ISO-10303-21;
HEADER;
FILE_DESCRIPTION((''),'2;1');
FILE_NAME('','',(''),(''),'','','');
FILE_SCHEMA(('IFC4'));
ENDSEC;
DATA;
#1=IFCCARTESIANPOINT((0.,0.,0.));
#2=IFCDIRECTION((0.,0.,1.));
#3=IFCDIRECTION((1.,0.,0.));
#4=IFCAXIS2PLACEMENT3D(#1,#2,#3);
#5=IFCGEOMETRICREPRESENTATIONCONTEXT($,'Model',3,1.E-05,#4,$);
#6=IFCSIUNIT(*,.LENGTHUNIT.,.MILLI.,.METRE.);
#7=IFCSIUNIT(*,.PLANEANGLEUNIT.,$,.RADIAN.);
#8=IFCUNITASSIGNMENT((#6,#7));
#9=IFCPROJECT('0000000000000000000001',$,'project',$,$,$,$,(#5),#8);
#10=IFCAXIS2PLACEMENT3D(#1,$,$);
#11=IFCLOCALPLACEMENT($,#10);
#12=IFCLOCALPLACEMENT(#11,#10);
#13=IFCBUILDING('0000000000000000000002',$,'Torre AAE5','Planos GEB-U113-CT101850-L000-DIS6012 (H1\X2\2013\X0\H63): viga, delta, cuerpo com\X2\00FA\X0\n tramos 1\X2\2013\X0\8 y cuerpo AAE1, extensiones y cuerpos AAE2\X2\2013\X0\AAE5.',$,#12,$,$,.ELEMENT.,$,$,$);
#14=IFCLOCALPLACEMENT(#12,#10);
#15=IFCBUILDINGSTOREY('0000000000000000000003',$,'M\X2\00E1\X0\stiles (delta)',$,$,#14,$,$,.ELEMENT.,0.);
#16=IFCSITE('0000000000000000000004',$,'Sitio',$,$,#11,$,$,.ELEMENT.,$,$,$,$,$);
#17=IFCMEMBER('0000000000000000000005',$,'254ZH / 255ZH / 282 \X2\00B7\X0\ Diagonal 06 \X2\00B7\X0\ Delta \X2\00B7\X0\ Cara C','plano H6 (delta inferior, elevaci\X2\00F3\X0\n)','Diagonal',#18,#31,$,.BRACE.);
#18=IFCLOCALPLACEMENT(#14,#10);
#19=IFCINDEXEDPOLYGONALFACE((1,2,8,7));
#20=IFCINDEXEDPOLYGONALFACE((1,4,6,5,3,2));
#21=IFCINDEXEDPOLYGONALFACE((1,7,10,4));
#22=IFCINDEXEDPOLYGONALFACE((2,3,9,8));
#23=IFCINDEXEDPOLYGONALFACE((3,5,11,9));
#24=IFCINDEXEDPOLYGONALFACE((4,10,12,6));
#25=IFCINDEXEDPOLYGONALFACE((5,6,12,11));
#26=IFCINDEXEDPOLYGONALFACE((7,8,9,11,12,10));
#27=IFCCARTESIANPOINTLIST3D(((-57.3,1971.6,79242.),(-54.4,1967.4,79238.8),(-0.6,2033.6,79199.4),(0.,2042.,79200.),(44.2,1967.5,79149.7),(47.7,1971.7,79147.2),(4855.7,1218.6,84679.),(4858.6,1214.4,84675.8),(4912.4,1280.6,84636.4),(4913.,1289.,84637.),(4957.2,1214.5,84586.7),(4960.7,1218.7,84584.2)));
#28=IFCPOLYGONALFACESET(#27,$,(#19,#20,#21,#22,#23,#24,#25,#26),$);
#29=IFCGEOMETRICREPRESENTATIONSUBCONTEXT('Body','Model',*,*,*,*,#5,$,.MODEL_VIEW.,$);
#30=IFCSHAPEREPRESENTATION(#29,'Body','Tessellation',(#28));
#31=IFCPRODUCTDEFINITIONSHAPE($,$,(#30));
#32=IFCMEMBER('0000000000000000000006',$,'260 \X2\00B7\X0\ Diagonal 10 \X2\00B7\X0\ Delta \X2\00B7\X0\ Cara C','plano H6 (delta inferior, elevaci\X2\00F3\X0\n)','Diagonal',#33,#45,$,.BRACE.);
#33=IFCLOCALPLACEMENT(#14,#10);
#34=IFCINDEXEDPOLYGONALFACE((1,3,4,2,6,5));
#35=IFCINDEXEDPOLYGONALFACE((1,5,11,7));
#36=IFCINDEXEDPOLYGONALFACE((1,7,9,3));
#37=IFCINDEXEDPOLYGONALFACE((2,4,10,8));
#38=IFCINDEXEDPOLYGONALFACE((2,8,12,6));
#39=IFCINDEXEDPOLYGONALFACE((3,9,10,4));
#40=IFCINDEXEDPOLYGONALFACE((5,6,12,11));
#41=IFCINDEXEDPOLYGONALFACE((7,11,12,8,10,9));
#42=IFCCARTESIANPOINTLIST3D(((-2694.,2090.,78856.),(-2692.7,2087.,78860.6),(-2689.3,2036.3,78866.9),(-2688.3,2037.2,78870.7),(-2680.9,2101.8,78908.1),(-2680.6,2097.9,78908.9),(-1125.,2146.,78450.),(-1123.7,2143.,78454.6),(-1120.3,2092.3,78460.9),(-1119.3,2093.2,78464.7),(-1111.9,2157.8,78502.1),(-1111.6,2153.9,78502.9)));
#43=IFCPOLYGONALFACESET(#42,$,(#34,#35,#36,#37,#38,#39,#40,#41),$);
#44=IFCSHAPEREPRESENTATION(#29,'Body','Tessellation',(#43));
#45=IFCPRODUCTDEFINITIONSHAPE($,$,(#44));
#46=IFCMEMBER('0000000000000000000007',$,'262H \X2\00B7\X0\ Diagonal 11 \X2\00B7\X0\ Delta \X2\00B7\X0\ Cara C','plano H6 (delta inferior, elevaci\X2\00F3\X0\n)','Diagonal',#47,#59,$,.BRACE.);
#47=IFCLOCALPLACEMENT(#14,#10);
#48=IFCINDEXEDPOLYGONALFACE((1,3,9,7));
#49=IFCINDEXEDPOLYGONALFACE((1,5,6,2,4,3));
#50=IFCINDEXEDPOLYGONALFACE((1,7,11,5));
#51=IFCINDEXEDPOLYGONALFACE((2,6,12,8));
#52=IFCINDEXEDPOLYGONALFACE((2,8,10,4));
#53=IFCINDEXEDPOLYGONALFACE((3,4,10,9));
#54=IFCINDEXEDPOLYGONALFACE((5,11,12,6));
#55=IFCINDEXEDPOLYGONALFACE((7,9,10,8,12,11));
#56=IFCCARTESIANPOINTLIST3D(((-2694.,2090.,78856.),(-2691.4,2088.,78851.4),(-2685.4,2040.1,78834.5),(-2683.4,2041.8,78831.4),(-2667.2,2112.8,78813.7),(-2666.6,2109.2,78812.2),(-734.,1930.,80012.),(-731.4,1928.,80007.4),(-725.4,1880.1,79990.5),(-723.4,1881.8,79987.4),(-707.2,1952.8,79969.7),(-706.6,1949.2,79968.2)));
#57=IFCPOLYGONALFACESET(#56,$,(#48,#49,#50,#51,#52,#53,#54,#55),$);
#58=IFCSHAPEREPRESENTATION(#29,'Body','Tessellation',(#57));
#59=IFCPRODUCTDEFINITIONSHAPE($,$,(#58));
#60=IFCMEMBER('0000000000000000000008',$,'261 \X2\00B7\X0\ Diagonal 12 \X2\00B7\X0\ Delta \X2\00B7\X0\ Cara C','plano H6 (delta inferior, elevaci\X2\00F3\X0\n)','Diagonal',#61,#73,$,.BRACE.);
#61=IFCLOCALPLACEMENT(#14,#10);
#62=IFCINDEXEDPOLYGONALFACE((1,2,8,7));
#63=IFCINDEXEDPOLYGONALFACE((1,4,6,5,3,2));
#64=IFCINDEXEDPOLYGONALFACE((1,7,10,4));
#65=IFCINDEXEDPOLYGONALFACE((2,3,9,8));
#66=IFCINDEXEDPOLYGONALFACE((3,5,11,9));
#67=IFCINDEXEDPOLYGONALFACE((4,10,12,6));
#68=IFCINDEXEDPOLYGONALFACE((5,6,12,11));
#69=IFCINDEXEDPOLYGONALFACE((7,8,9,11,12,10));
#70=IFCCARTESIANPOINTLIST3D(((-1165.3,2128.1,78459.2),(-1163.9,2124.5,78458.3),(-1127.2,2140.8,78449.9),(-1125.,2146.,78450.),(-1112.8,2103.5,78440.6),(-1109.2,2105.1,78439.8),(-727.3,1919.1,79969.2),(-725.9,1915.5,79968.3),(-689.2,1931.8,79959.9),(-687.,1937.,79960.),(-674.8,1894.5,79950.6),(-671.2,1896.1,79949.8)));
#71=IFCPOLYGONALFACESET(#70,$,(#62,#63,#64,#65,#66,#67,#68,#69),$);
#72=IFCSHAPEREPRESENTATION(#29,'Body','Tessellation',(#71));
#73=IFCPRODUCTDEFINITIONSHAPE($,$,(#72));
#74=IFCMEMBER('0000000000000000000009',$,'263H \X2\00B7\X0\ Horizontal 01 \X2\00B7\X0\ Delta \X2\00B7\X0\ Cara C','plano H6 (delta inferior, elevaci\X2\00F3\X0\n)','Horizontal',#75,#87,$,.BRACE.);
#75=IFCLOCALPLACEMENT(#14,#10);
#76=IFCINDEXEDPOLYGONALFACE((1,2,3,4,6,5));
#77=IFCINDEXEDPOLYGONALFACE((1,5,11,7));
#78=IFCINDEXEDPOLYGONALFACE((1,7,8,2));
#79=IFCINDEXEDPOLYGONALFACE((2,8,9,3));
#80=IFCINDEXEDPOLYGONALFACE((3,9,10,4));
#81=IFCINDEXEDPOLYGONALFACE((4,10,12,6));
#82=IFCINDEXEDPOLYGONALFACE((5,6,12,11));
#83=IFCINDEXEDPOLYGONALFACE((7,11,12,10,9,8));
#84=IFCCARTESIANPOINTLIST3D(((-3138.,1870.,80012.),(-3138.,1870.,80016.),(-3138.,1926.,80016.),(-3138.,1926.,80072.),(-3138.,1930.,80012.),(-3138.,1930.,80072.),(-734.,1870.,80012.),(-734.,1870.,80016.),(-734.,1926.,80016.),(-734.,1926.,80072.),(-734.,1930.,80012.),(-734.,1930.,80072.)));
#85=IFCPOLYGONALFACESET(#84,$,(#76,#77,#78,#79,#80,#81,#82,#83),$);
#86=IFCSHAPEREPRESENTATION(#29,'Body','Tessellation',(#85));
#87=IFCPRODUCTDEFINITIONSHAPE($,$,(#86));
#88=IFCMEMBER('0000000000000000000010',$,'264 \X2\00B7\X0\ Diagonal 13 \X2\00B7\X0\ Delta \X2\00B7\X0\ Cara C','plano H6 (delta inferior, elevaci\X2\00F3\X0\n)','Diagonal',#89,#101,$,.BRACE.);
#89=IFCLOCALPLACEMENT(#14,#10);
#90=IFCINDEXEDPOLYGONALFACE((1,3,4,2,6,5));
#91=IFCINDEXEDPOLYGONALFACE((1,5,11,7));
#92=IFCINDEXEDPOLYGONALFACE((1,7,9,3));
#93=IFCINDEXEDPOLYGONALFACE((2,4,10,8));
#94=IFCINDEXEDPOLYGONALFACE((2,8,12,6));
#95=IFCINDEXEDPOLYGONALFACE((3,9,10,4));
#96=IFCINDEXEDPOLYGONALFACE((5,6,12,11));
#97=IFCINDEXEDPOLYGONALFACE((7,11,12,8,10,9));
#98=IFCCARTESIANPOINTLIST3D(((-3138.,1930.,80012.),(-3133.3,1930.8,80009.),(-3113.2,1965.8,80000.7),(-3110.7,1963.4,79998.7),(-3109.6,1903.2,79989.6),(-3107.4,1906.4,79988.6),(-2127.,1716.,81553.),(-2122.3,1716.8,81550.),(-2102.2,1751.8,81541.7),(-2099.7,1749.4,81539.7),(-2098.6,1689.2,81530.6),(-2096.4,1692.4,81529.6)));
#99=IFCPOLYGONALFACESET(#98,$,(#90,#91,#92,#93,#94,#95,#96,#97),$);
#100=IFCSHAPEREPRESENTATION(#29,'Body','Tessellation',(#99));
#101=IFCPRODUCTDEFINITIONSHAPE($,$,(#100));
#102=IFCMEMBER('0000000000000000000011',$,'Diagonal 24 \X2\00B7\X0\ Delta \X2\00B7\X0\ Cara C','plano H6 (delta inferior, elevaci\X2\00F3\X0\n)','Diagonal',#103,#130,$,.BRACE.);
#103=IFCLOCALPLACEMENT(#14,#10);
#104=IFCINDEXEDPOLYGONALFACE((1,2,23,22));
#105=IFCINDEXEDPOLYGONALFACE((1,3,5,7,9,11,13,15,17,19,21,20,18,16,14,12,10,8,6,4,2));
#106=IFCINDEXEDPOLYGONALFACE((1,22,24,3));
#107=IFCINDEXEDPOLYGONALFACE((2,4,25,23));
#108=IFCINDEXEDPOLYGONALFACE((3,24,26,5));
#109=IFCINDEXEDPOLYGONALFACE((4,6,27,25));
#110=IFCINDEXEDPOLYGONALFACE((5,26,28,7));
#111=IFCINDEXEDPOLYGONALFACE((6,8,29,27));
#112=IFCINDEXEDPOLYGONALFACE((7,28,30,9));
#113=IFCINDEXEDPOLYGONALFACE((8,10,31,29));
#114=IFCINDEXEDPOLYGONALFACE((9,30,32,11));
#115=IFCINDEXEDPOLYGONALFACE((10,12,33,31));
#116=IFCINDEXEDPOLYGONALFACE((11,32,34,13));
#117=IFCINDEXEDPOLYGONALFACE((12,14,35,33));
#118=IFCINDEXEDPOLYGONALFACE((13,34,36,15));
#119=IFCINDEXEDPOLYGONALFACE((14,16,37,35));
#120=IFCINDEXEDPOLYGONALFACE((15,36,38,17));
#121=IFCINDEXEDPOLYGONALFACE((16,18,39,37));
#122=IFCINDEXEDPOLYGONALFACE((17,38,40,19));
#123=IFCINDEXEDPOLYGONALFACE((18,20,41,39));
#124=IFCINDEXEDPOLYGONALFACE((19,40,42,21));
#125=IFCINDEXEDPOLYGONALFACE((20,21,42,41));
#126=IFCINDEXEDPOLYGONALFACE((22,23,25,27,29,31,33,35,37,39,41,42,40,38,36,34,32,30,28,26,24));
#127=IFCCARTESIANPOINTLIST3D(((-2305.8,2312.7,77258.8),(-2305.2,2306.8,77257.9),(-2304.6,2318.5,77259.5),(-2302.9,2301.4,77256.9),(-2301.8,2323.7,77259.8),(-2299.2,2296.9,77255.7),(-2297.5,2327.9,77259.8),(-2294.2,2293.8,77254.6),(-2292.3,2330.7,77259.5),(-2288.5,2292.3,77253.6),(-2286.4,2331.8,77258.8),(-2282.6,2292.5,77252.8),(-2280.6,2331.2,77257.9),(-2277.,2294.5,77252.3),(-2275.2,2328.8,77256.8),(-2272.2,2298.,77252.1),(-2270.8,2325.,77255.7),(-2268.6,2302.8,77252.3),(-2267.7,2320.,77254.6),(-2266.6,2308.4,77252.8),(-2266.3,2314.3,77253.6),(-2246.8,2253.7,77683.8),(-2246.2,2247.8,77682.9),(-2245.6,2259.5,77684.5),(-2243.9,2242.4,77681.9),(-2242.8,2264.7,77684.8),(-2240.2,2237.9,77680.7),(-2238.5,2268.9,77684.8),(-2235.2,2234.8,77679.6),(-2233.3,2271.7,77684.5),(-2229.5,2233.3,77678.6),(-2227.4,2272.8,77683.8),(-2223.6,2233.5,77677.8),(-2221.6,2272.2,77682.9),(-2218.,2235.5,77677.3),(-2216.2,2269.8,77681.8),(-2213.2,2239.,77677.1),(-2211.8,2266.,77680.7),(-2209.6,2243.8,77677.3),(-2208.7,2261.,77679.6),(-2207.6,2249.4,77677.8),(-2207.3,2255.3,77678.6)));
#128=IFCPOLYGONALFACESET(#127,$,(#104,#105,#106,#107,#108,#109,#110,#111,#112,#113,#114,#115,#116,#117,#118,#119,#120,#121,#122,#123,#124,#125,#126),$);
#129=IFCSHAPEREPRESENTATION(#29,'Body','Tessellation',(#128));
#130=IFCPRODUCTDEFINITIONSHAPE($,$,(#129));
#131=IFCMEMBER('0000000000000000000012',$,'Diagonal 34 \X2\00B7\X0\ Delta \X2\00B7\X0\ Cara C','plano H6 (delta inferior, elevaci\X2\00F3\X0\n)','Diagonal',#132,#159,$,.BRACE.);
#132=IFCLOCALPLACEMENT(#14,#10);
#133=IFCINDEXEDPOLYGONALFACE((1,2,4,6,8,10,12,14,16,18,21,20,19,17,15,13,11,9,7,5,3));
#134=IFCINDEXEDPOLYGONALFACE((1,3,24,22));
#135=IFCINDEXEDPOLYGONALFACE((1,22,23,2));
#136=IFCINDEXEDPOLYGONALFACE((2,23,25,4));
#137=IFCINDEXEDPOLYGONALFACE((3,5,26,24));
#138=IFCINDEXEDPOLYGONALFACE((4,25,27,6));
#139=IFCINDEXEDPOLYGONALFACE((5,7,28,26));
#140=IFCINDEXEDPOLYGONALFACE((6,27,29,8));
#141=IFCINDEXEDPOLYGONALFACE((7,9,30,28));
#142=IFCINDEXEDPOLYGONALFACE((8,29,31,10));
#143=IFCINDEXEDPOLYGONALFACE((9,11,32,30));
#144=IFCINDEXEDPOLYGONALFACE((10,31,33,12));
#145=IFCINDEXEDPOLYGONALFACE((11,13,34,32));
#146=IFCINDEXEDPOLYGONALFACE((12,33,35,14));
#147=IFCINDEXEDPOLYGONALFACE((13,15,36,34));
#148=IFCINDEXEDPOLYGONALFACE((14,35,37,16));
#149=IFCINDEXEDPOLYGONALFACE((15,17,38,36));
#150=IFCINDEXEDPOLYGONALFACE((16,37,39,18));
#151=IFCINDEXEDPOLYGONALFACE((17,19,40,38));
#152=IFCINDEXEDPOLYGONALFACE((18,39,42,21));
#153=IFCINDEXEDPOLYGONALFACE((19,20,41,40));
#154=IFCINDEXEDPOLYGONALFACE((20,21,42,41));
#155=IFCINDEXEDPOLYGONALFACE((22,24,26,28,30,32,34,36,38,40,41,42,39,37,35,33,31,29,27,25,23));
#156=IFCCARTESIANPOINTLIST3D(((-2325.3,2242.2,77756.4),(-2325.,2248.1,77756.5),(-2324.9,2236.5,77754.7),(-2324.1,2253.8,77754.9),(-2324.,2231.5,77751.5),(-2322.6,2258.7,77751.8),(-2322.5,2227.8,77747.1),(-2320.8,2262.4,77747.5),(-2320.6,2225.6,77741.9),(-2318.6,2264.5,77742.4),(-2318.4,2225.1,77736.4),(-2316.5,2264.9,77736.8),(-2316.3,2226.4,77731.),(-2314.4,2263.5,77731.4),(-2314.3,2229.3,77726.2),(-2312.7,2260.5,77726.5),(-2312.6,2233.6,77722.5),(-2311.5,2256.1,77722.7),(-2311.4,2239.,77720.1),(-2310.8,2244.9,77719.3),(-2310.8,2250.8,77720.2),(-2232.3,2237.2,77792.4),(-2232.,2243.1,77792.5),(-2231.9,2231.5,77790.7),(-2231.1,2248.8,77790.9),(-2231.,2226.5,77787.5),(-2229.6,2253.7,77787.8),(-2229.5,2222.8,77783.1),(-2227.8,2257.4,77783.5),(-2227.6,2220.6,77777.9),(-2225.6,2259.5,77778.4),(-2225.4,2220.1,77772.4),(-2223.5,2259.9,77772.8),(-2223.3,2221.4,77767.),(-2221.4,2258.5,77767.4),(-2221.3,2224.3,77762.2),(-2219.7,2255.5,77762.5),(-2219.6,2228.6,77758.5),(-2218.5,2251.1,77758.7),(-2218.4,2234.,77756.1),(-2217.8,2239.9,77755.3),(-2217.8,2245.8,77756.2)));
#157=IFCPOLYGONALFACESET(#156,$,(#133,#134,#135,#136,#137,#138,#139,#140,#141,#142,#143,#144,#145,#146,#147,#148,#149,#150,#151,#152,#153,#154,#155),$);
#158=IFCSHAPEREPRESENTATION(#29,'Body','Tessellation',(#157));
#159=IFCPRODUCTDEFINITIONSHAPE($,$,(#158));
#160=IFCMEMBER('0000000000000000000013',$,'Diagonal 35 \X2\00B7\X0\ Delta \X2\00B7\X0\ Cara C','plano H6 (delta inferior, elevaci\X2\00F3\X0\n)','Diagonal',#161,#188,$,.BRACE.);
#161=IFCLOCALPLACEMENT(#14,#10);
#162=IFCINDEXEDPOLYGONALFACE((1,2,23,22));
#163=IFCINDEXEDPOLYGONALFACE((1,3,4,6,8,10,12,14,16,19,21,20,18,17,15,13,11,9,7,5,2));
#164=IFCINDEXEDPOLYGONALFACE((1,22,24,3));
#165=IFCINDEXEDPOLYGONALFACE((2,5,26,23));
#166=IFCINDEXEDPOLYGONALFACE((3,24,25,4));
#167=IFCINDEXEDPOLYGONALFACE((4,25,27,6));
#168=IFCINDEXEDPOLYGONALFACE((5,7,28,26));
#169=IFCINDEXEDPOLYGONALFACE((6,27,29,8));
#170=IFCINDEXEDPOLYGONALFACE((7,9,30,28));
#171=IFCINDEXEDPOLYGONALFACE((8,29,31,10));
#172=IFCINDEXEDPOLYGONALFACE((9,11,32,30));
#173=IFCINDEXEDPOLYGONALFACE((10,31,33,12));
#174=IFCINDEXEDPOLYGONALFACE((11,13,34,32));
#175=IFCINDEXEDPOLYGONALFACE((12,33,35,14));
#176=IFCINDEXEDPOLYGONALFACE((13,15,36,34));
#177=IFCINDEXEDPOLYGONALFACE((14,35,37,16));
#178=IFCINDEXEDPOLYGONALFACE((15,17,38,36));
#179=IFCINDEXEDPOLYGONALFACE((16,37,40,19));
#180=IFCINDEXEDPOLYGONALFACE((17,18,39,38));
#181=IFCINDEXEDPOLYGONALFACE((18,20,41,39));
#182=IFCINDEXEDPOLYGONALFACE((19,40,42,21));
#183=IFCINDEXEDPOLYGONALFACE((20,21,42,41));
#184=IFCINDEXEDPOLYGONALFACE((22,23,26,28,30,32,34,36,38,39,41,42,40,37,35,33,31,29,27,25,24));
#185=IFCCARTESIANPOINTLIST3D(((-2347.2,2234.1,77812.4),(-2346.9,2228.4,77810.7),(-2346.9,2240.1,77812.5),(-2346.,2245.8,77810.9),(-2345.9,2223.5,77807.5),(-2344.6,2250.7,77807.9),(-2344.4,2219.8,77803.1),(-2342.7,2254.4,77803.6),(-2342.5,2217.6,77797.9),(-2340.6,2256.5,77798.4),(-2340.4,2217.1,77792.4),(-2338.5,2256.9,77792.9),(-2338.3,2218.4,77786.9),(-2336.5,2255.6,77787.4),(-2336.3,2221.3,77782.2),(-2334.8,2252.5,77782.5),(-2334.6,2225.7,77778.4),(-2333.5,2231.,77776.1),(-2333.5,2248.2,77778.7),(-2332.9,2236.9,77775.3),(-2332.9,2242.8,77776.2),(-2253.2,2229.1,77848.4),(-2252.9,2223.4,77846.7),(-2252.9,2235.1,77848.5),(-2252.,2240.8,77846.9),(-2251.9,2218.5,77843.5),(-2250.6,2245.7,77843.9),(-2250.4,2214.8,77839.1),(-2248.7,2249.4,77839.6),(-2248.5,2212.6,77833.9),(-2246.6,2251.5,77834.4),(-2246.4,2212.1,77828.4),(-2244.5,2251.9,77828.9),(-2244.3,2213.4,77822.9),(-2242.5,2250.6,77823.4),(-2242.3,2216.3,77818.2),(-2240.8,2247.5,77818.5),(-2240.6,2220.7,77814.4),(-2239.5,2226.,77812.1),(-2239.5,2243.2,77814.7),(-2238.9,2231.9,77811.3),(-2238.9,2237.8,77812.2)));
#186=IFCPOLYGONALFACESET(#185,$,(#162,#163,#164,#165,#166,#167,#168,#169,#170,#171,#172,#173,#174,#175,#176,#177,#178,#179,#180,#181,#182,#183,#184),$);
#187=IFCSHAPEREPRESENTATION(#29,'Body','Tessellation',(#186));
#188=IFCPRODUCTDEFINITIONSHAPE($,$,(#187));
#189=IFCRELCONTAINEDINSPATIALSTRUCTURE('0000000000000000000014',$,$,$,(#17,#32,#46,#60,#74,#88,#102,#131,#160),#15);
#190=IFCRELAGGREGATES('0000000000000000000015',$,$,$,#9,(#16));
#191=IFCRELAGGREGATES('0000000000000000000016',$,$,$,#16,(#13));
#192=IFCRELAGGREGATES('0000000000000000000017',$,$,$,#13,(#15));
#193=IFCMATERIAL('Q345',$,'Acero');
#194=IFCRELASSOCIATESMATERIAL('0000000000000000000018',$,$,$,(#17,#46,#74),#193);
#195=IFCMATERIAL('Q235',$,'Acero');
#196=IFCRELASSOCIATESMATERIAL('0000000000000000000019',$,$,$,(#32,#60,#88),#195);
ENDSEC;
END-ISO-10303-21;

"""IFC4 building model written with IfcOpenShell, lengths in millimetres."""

from ifc_helpers import new_model, si_unit, frame, frame_2d, origin, origin_with_axes, place, context, subcontext, project, spatial, circle, l_section, extrude, material, element, save


model = new_model("IFC4")

# Units and contexts
model_context = context("Model", 3, precision=1e-05, world=origin_with_axes())
body_context = subcontext(model_context, "Body", "Model", "MODEL_VIEW")
ifc_project = project(units=[si_unit("LENGTHUNIT", "METRE", prefix="MILLI"), si_unit("PLANEANGLEUNIT", "RADIAN")], contexts=[model_context])

# Site, building, storey
site_placement = place(None, origin())
site = spatial("IfcSite", under=ifc_project, at=site_placement, Name="Sitio", CompositionType="ELEMENT")
building_placement = place(site_placement, origin())
building = spatial("IfcBuilding", under=site, at=building_placement, Name="Torre AAE5", Description="Planos GEB-U113-CT101850-L000-DIS6012 (H1–H63): viga, delta, cuerpo común tramos 1–8 y cuerpo AAE1, extensiones y cuerpos AAE2–AAE5.", CompositionType="ELEMENT")
storey_placement = place(building_placement, origin())
storey = spatial("IfcBuildingStorey", under=building, at=storey_placement, Name="Mástiles (delta)", CompositionType="ELEMENT", Elevation=0.0)

# Members
ifc_material_1 = material(Name="Q345", Category="Acero")
member_1_placement = place(storey_placement, frame((0.0, 2042.0, 79200.0), z_axis=(0.666937, -0.102219, 0.738069), x_axis=(-0.572774, -0.703887, 0.420087)))
element("IfcMember", 1, at=member_1_placement, inside=storey, material=ifc_material_1, Name="254ZH / 255ZH / 282 · Diagonal 06 · Delta · Cara C", Description="plano H6 (delta inferior, elevación)", ObjectType="Diagonal", PredefinedType="BRACE", context=body_context, shape_type="SweptSolid", body=[
    extrude(l_section(Depth=100.0, Width=100.0, Thickness=6.0, at=frame_2d((50.0, 50.0))), None, (0.0, 0.0, 1.0), 7366.5),
])
ifc_material_2 = material(Name="Q235", Category="Acero")
member_2_placement = place(storey_placement, frame((-1125.0, 2146.0, 78450.0), z_axis=(-0.967536, -0.034533, 0.250363), x_axis=(0.086334, -0.976191, 0.198993)))
element("IfcMember", 2, at=member_2_placement, inside=storey, material=ifc_material_2, Name="260 · Diagonal 10 · Delta · Cara C", Description="plano H6 (delta inferior, elevación)", ObjectType="Diagonal", PredefinedType="BRACE", context=body_context, shape_type="SweptSolid", body=[
    extrude(l_section(Depth=55.0, Width=55.0, Thickness=4.0, at=frame_2d((27.5, 27.5))), None, (0.0, 0.0, 1.0), 1621.6),
])
member_3_placement = place(storey_placement, frame((-2694.0, 2090.0, 78856.0), z_axis=(0.859225, -0.070141, 0.506767), x_axis=(0.156582, -0.906966, -0.391017)))
element("IfcMember", 3, at=member_3_placement, inside=storey, material=ifc_material_1, Name="262H · Diagonal 11 · Delta · Cara C", Description="plano H6 (delta inferior, elevación)", ObjectType="Diagonal", PredefinedType="BRACE", context=body_context, shape_type="SweptSolid", body=[
    extrude(l_section(Depth=55.0, Width=55.0, Thickness=4.0, at=frame_2d((27.5, 27.5))), None, (0.0, 0.0, 1.0), 2281.1),
])
member_4_placement = place(storey_placement, frame((-687.0, 1937.0, 79960.0), z_axis=(-0.276154, 0.131772, -0.952037), x_axis=(0.351062, -0.908283, -0.227547)))
element("IfcMember", 4, at=member_4_placement, inside=storey, material=ifc_material_2, Name="261 · Diagonal 12 · Delta · Cara C", Description="plano H6 (delta inferior, elevación)", ObjectType="Diagonal", PredefinedType="BRACE", context=body_context, shape_type="SweptSolid", body=[
    extrude(l_section(Depth=45.0, Width=45.0, Thickness=4.0, at=frame_2d((22.5, 22.5))), None, (0.0, 0.0, 1.0), 1586.1),
])
member_5_placement = place(storey_placement, frame((-734.0, 1930.0, 80012.0), z_axis=(-1.0, 0.0, 0.0), x_axis=(0.0, -1.0, 0.0)))
element("IfcMember", 5, at=member_5_placement, inside=storey, material=ifc_material_1, Name="263H · Horizontal 01 · Delta · Cara C", Description="plano H6 (delta inferior, elevación)", ObjectType="Horizontal", PredefinedType="BRACE", context=body_context, shape_type="SweptSolid", body=[
    extrude(l_section(Depth=60.0, Width=60.0, Thickness=4.0, at=frame_2d((30.0, 30.0))), None, (0.0, 0.0, 1.0), 2404.0),
])
member_6_placement = place(storey_placement, frame((-3138.0, 1930.0, 80012.0), z_axis=(0.544889, -0.115338, 0.830538), x_axis=(0.631982, -0.594484, -0.49718)))
element("IfcMember", 6, at=member_6_placement, inside=storey, material=ifc_material_2, Name="264 · Diagonal 13 · Delta · Cara C", Description="plano H6 (delta inferior, elevación)", ObjectType="Diagonal", PredefinedType="BRACE", context=body_context, shape_type="SweptSolid", body=[
    extrude(l_section(Depth=45.0, Width=45.0, Thickness=4.0, at=frame_2d((22.5, 22.5))), None, (0.0, 0.0, 1.0), 1855.4),
])
member_7_placement = place(storey_placement, frame((-2227.0, 2253.0, 77681.0), z_axis=(-0.136223, 0.136223, -0.981268), x_axis=(0.689722, -0.697977, -0.192645)))
element("IfcMember", 7, at=member_7_placement, inside=storey, Name="Diagonal 24 · Delta · Cara C", Description="plano H6 (delta inferior, elevación)", ObjectType="Diagonal", PredefinedType="BRACE", context=body_context, shape_type="SweptSolid", body=[
    extrude(circle(Radius=20.0), None, (0.0, 0.0, 1.0), 433.1),
])
member_8_placement = place(storey_placement, frame((-2318.0, 2245.0, 77738.0), z_axis=(0.931398, -0.050075, 0.360541), x_axis=(0.085914, -0.932266, -0.351425)))
element("IfcMember", 8, at=member_8_placement, inside=storey, Name="Diagonal 34 · Delta · Cara C", Description="plano H6 (delta inferior, elevación)", ObjectType="Diagonal", PredefinedType="BRACE", context=body_context, shape_type="SweptSolid", body=[
    extrude(circle(Radius=20.0), None, (0.0, 0.0, 1.0), 99.8),
])
member_9_placement = place(storey_placement, frame((-2340.0, 2237.0, 77794.0), z_axis=(0.932707, -0.049612, 0.357207), x_axis=(0.085516, -0.931817, -0.35271)))
element("IfcMember", 9, at=member_9_placement, inside=storey, Name="Diagonal 35 · Delta · Cara C", Description="plano H6 (delta inferior, elevación)", ObjectType="Diagonal", PredefinedType="BRACE", context=body_context, shape_type="SweptSolid", body=[
    extrude(circle(Radius=20.0), None, (0.0, 0.0, 1.0), 100.8),
])

save(model, "model.ifc")
